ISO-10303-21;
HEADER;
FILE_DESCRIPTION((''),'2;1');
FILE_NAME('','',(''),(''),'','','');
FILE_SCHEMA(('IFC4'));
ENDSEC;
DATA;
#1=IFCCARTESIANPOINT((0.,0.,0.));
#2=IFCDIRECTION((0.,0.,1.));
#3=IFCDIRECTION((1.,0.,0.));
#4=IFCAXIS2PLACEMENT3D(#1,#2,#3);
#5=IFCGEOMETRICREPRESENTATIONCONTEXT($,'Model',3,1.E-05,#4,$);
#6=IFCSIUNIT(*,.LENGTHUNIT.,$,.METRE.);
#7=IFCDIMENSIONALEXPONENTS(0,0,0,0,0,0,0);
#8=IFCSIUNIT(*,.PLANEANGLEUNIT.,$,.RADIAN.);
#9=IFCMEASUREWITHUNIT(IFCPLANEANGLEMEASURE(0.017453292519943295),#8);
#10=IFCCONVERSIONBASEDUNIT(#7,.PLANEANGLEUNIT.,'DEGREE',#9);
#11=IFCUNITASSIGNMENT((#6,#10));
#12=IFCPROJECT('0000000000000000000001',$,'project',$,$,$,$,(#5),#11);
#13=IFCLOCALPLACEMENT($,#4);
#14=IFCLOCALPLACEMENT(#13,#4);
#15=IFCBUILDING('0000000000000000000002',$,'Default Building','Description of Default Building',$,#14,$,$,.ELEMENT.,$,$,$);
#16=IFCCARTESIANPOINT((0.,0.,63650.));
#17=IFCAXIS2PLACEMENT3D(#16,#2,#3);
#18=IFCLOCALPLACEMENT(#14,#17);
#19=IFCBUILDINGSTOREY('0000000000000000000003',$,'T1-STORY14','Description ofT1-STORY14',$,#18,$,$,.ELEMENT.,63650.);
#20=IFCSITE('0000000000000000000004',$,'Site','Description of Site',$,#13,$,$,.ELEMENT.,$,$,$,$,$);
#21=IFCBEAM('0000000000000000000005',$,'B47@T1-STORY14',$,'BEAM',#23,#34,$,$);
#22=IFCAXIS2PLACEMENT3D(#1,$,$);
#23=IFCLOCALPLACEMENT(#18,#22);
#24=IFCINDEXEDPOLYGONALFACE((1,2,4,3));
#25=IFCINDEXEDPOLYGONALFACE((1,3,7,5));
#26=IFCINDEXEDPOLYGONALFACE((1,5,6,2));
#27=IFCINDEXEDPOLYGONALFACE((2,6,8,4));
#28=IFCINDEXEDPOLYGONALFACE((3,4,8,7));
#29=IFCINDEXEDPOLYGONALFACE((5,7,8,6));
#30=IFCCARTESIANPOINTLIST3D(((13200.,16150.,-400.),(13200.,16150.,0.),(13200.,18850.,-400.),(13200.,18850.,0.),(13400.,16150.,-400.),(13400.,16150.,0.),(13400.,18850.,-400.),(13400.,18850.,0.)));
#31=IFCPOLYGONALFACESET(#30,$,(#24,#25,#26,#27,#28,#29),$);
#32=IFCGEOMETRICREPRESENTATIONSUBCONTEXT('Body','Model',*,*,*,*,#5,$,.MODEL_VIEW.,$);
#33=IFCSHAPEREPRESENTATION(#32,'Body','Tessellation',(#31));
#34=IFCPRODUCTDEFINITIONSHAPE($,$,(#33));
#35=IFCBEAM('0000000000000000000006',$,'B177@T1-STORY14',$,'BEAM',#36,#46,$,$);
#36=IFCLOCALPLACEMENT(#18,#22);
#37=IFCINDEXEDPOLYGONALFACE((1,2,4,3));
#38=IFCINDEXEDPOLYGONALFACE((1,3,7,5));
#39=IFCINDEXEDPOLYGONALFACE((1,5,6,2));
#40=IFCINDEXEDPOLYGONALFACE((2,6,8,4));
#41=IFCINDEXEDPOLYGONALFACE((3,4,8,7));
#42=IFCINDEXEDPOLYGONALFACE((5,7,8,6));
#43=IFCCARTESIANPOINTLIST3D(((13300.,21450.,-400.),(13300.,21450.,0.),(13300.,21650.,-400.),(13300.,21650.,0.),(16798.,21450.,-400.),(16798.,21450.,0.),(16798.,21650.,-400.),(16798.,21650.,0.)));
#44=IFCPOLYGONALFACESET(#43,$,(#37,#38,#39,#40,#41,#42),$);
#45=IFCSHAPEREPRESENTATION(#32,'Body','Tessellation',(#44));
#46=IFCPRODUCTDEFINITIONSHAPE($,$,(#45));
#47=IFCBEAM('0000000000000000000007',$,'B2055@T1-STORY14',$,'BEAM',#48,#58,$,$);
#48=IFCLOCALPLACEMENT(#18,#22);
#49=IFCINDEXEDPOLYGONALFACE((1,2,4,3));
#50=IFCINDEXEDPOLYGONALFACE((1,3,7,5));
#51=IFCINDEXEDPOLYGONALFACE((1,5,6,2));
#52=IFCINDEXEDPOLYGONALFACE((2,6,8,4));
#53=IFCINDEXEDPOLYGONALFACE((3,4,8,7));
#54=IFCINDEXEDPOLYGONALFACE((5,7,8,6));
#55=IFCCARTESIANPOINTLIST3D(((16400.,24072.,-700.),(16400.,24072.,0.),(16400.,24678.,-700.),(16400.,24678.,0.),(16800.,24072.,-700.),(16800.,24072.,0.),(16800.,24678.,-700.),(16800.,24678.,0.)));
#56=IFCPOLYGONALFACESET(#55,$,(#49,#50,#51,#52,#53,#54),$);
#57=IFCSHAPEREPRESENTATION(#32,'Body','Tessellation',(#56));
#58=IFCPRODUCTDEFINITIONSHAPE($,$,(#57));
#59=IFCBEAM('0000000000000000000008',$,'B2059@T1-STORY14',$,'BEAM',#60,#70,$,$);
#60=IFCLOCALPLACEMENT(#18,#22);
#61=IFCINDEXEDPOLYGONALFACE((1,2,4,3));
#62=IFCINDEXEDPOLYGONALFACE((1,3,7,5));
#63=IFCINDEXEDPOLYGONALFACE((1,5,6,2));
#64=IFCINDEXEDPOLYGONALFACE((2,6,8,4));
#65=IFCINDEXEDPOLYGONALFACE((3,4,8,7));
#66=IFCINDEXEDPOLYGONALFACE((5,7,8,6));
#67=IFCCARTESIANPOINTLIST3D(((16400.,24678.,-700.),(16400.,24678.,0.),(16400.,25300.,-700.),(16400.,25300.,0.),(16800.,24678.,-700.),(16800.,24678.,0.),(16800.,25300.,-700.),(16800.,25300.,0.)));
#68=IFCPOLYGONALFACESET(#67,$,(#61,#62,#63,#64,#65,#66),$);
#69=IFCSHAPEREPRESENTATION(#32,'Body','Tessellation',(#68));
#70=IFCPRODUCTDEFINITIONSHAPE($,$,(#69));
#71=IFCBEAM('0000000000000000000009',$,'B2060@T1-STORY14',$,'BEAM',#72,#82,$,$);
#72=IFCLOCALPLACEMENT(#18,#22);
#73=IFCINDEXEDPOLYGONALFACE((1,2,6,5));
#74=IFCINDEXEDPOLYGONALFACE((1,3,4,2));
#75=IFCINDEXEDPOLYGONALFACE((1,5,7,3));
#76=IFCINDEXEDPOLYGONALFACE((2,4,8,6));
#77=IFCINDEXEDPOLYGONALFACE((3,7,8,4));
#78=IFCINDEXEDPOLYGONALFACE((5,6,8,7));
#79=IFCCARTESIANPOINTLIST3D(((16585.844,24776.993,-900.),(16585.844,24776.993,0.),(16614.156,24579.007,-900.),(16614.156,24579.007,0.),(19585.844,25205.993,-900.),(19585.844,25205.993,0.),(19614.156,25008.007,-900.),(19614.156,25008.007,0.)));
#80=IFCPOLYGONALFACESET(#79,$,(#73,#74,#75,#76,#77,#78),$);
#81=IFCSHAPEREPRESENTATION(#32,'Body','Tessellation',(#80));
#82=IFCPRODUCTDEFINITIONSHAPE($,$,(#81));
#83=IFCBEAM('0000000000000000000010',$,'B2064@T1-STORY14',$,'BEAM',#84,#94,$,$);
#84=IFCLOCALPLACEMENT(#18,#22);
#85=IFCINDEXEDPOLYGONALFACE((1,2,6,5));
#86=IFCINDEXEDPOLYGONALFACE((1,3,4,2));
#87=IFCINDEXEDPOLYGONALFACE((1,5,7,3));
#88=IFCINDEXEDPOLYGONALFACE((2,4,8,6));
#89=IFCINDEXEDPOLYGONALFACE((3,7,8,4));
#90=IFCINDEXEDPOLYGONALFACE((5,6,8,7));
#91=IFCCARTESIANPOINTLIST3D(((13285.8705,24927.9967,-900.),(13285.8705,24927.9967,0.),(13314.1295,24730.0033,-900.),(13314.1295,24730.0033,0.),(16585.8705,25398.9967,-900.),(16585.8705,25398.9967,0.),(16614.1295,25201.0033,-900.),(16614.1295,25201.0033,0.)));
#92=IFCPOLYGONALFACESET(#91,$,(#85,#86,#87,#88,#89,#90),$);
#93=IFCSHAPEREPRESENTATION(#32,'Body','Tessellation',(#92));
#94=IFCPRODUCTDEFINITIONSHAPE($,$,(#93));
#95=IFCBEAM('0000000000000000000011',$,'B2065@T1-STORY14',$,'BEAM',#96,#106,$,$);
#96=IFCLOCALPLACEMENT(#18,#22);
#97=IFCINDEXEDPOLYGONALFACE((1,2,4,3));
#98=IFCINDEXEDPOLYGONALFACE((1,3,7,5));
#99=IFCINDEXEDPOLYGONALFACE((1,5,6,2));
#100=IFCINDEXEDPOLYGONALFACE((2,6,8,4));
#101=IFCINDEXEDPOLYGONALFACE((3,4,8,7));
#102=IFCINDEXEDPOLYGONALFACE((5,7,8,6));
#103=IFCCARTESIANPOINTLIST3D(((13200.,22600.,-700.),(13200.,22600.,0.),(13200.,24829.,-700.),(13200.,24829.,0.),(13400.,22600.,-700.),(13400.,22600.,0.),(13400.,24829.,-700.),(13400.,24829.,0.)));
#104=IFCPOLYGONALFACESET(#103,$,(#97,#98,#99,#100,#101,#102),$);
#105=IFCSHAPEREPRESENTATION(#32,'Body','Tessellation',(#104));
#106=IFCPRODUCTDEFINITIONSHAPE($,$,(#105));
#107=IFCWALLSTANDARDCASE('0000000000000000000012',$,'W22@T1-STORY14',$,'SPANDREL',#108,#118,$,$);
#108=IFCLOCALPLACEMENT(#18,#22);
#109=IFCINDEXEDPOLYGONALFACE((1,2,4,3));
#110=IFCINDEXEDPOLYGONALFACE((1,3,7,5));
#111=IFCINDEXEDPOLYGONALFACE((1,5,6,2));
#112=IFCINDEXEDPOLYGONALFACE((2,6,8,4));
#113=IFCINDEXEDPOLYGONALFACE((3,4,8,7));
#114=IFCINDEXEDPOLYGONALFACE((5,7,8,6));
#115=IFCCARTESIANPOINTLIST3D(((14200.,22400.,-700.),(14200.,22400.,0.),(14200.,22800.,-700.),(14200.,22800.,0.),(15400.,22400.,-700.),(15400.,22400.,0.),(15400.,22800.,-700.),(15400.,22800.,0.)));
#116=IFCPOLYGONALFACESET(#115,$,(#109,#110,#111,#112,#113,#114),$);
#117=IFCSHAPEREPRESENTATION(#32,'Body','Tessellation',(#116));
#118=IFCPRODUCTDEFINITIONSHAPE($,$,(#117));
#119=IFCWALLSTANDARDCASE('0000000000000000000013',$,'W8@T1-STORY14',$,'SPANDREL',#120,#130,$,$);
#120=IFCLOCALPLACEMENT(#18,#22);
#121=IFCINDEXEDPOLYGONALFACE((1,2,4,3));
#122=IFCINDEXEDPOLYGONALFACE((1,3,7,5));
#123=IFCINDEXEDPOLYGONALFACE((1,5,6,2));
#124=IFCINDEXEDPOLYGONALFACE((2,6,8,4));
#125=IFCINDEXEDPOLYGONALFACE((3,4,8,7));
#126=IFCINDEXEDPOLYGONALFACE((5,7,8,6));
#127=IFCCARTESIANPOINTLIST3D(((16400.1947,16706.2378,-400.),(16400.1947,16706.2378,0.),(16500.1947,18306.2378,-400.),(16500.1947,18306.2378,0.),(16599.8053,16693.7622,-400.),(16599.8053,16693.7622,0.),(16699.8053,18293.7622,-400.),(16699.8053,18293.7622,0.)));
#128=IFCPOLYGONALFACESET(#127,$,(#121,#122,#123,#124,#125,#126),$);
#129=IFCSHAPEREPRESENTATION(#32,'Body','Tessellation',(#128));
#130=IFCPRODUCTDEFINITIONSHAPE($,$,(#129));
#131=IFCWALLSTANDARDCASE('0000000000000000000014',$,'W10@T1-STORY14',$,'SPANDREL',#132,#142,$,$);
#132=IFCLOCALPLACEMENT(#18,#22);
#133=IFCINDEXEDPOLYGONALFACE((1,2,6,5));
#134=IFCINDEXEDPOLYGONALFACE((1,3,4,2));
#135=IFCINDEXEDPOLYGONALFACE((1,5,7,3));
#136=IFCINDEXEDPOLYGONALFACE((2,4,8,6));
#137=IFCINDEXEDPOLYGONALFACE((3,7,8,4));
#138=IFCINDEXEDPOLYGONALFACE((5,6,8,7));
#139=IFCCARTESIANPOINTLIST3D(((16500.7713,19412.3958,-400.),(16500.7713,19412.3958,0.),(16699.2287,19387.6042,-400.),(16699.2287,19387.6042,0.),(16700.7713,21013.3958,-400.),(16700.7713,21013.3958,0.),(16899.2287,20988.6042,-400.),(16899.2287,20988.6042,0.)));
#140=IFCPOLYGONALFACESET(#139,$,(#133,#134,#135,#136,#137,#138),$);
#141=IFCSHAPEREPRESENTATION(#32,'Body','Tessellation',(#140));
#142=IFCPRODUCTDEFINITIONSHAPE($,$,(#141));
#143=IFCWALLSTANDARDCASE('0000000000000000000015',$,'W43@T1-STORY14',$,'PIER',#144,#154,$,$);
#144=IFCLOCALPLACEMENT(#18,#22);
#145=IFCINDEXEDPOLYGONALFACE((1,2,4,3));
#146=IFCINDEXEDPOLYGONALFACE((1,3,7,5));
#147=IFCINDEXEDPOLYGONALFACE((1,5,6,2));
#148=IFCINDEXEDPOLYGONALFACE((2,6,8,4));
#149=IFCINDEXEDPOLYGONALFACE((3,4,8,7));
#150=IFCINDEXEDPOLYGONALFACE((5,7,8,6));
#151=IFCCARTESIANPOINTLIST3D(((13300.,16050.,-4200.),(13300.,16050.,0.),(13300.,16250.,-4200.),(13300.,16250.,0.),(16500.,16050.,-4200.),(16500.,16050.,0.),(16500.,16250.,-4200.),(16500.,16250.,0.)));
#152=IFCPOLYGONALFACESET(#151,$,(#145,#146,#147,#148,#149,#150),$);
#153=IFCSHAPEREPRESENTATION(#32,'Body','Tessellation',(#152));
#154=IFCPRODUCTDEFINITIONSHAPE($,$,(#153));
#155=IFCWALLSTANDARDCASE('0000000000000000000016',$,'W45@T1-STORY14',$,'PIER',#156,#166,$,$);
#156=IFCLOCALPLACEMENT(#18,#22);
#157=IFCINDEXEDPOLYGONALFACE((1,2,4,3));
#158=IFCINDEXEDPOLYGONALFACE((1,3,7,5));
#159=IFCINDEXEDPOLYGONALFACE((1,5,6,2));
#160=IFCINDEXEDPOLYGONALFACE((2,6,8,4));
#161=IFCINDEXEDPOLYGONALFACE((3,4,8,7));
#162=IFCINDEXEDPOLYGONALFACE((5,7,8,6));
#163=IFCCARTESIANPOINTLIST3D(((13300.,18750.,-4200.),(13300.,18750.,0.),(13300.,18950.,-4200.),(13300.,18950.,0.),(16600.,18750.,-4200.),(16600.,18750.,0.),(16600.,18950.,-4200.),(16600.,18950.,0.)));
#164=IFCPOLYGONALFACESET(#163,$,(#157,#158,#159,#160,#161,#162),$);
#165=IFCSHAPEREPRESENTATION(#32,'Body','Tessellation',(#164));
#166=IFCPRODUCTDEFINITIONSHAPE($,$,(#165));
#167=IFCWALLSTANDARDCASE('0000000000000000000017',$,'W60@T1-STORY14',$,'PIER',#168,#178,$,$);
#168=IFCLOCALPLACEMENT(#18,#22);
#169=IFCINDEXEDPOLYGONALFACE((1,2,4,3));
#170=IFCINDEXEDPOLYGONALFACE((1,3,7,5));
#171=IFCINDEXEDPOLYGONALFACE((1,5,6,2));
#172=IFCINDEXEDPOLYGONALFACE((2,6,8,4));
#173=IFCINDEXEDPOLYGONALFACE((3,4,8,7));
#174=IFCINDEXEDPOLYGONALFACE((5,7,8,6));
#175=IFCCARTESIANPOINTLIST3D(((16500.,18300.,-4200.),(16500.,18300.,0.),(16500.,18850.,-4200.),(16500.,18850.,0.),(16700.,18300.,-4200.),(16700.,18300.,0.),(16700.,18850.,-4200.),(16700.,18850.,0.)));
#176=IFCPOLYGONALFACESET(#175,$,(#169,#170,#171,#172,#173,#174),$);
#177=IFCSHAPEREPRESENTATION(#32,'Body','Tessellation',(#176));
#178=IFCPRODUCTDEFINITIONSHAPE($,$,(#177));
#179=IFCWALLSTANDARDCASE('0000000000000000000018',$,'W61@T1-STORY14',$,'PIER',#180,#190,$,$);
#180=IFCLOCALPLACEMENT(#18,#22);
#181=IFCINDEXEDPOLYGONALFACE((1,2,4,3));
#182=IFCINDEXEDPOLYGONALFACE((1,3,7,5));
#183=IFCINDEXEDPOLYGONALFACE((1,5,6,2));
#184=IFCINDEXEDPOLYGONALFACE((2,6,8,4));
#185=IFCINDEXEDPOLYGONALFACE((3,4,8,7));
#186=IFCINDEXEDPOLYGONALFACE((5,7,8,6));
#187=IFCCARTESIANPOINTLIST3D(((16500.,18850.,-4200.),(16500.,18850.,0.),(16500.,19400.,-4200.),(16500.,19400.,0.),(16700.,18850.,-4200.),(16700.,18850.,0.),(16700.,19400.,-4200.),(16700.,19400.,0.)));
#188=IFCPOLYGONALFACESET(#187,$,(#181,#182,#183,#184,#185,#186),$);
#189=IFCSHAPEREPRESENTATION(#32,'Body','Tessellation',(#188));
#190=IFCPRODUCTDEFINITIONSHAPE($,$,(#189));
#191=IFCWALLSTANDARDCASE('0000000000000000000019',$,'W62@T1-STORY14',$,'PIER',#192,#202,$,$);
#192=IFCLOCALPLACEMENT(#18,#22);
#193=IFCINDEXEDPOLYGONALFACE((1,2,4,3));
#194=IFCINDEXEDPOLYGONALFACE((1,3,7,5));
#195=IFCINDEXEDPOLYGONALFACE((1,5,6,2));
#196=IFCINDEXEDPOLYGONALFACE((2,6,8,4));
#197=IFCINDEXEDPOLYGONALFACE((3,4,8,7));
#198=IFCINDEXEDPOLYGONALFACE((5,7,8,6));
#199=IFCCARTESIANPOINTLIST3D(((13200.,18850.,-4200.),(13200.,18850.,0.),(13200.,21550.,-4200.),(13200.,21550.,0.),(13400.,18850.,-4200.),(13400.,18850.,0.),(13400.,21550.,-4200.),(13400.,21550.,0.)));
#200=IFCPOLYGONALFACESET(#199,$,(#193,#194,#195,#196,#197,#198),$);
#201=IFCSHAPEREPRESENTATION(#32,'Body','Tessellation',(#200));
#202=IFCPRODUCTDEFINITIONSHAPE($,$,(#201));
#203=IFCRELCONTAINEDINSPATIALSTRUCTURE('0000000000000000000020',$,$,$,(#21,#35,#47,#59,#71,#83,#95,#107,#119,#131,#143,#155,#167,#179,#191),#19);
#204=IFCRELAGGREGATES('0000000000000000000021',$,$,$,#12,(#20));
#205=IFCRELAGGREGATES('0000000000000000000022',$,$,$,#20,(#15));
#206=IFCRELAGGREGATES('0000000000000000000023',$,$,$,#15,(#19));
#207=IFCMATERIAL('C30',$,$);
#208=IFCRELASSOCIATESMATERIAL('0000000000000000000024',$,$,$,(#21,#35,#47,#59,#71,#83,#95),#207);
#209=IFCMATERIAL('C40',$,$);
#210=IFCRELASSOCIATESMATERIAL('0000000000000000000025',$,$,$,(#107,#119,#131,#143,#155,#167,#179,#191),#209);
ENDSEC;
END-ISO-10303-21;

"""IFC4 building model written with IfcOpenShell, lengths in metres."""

from ifc_helpers import new_model, entity, si_unit, converted_unit, frame, origin_with_axes, place, context, subcontext, project, spatial, indexed_curve, rectangle, outline, extrude, material, element, save


model = new_model("IFC4")

# Units and contexts
model_context = context("Model", 3, precision=1e-05, world=origin_with_axes())
body_context = subcontext(model_context, "Body", "Model", "MODEL_VIEW")
ifc_project = project(units=[si_unit("LENGTHUNIT", "METRE"), converted_unit("PLANEANGLEUNIT", "DEGREE", entity("IfcPlaneAngleMeasure", 0.017453292519943295), si_unit("PLANEANGLEUNIT", "RADIAN"), dimensions=[0, 0, 0, 0, 0, 0, 0])], contexts=[model_context])

# Site, building, storey
site_placement = place(None, origin_with_axes())
site = spatial("IfcSite", under=ifc_project, at=site_placement, Name="Site", Description="Description of Site", CompositionType="ELEMENT")
building_placement = place(site_placement, origin_with_axes())
building = spatial("IfcBuilding", under=site, at=building_placement, Name="Default Building", Description="Description of Default Building", CompositionType="ELEMENT")
storey_placement = place(building_placement, frame((0.0, 0.0, 63650.0), z_axis=(0.0, 0.0, 1.0), x_axis=(1.0, 0.0, 0.0)))
storey = spatial("IfcBuildingStorey", under=building, at=storey_placement, Name="T1-STORY14", Description="Description ofT1-STORY14", CompositionType="ELEMENT", Elevation=63650.0)

# Beams
ifc_material_1 = material(Name="C30")
beam_1_placement = place(storey_placement, frame((13300.0, 16150.0, -200.0), z_axis=(0.0, 1.0, 0.0), x_axis=(-1.0, 0.0, 0.0)))
element("IfcBeam", 1, at=beam_1_placement, inside=storey, material=ifc_material_1, Name="B47@T1-STORY14", ObjectType="BEAM", context=body_context, shape_type="SweptSolid", body=[
    extrude(rectangle(XDim=200.0, YDim=400.0), origin_with_axes(), (0.0, 0.0, 1.0), 2700.0),
])
beam_2_placement = place(storey_placement, frame((13300.0, 21550.0, -200.0), z_axis=(1.0, 0.0, 0.0), x_axis=(0.0, 1.0, 0.0)))
element("IfcBeam", 2, at=beam_2_placement, inside=storey, material=ifc_material_1, Name="B177@T1-STORY14", ObjectType="BEAM", context=body_context, shape_type="SweptSolid", body=[
    extrude(rectangle(XDim=200.0, YDim=400.0), origin_with_axes(), (0.0, 0.0, 1.0), 3498.0),
])
beam_3_placement = place(storey_placement, frame((16600.0, 24072.0, -350.0), z_axis=(0.0, 1.0, 0.0), x_axis=(-1.0, 0.0, 0.0)))
element("IfcBeam", 3, at=beam_3_placement, inside=storey, material=ifc_material_1, Name="B2055@T1-STORY14", ObjectType="BEAM", context=body_context, shape_type="SweptSolid", body=[
    extrude(rectangle(XDim=400.0, YDim=700.0), origin_with_axes(), (0.0, 0.0, 1.0), 606.0),
])
beam_4_placement = place(storey_placement, frame((16600.0, 24678.0, -350.0), z_axis=(0.0, 1.0, 0.0), x_axis=(-1.0, 0.0, 0.0)))
element("IfcBeam", 4, at=beam_4_placement, inside=storey, material=ifc_material_1, Name="B2059@T1-STORY14", ObjectType="BEAM", context=body_context, shape_type="SweptSolid", body=[
    extrude(rectangle(XDim=400.0, YDim=700.0), origin_with_axes(), (0.0, 0.0, 1.0), 622.0),
])
beam_5_placement = place(storey_placement, frame((16600.0, 24678.0, -450.0), z_axis=(0.98993, 0.14156, 0.0), x_axis=(-0.14156, 0.98993, 0.0)))
element("IfcBeam", 5, at=beam_5_placement, inside=storey, material=ifc_material_1, Name="B2060@T1-STORY14", ObjectType="BEAM", context=body_context, shape_type="SweptSolid", body=[
    extrude(rectangle(XDim=200.0, YDim=900.0), origin_with_axes(), (0.0, 0.0, 1.0), 3030.5183),
])
beam_6_placement = place(storey_placement, frame((13300.0, 24829.0, -450.0), z_axis=(0.989967, 0.141295, 0.0), x_axis=(-0.141295, 0.989967, 0.0)))
element("IfcBeam", 6, at=beam_6_placement, inside=storey, material=ifc_material_1, Name="B2064@T1-STORY14", ObjectType="BEAM", context=body_context, shape_type="SweptSolid", body=[
    extrude(rectangle(XDim=200.0, YDim=900.0), origin_with_axes(), (0.0, 0.0, 1.0), 3333.4428),
])
beam_7_placement = place(storey_placement, frame((13300.0, 22600.0, -350.0), z_axis=(0.0, 1.0, 0.0), x_axis=(-1.0, 0.0, 0.0)))
element("IfcBeam", 7, at=beam_7_placement, inside=storey, material=ifc_material_1, Name="B2065@T1-STORY14", ObjectType="BEAM", context=body_context, shape_type="SweptSolid", body=[
    extrude(rectangle(XDim=200.0, YDim=700.0), origin_with_axes(), (0.0, 0.0, 1.0), 2229.0),
])

# Walls
ifc_material_2 = material(Name="C40")
wall_1_placement = place(storey_placement, frame((14200.0, 22600.0, -700.0), z_axis=(0.0, 0.0, 1.0), x_axis=(1.0, 0.0, 0.0)))
element("IfcWallStandardCase", 8, at=wall_1_placement, inside=storey, material=ifc_material_2, Name="W22@T1-STORY14", ObjectType="SPANDREL", context=body_context, shape_type="SweptSolid", body=[
    extrude(outline(indexed_curve([(0.0, -200.0), (0.0, 200.0), (1200.0, 200.0), (1200.0, -200.0), (0.0, -200.0)], self_intersect=False)), origin_with_axes(), (0.0, 0.0, 1.0), 700.0),
])
wall_2_placement = place(storey_placement, frame((16500.0, 16700.0, -400.0), z_axis=(0.0, 0.0, 1.0), x_axis=(0.062378, 0.998053, 0.0)))
element("IfcWallStandardCase", 9, at=wall_2_placement, inside=storey, material=ifc_material_2, Name="W8@T1-STORY14", ObjectType="SPANDREL", context=body_context, shape_type="SweptSolid", body=[
    extrude(outline(indexed_curve([(0.0, -100.0), (0.0, 100.0), (1603.122, 100.0), (1603.122, -100.0), (0.0, -100.0)], self_intersect=False)), origin_with_axes(), (0.0, 0.0, 1.0), 400.0),
])
wall_3_placement = place(storey_placement, frame((16600.0, 19400.0, -400.0), z_axis=(0.0, 0.0, 1.0), x_axis=(0.123958, 0.992287, 0.0)))
element("IfcWallStandardCase", 10, at=wall_3_placement, inside=storey, material=ifc_material_2, Name="W10@T1-STORY14", ObjectType="SPANDREL", context=body_context, shape_type="SweptSolid", body=[
    extrude(outline(indexed_curve([(0.0, -100.0), (0.0, 100.0), (1613.4438, 100.0), (1613.4438, -100.0), (0.0, -100.0)], self_intersect=False)), origin_with_axes(), (0.0, 0.0, 1.0), 400.0),
])
wall_4_placement = place(storey_placement, frame((13300.0, 16150.0, -4200.0), z_axis=(0.0, 0.0, 1.0), x_axis=(1.0, 0.0, 0.0)))
element("IfcWallStandardCase", 11, at=wall_4_placement, inside=storey, material=ifc_material_2, Name="W43@T1-STORY14", ObjectType="PIER", context=body_context, shape_type="SweptSolid", body=[
    extrude(outline(indexed_curve([(0.0, -100.0), (0.0, 100.0), (3200.0, 100.0), (3200.0, -100.0), (0.0, -100.0)], self_intersect=False)), origin_with_axes(), (0.0, 0.0, 1.0), 4200.0),
])
wall_5_placement = place(storey_placement, frame((13300.0, 18850.0, -4200.0), z_axis=(0.0, 0.0, 1.0), x_axis=(1.0, 0.0, 0.0)))
element("IfcWallStandardCase", 12, at=wall_5_placement, inside=storey, material=ifc_material_2, Name="W45@T1-STORY14", ObjectType="PIER", context=body_context, shape_type="SweptSolid", body=[
    extrude(outline(indexed_curve([(0.0, -100.0), (0.0, 100.0), (3300.0, 100.0), (3300.0, -100.0), (0.0, -100.0)], self_intersect=False)), origin_with_axes(), (0.0, 0.0, 1.0), 4200.0),
])
for number, where, z_axis, x_axis, name in (
    (13, (16600.0, 18300.0, -4200.0), (0.0, 0.0, 1.0), (0.0, 1.0, 0.0), "W60@T1-STORY14"),
    (14, (16600.0, 18850.0, -4200.0), (0.0, 0.0, 1.0), (0.0, 1.0, 0.0), "W61@T1-STORY14"),
):
    element("IfcWallStandardCase", number, at=place(storey_placement, frame(where, z_axis=z_axis, x_axis=x_axis)), inside=storey, material=ifc_material_2, Name=name, ObjectType="PIER", context=body_context, shape_type="SweptSolid", body=[
        extrude(outline(indexed_curve([(0.0, -100.0), (0.0, 100.0), (550.0, 100.0), (550.0, -100.0), (0.0, -100.0)], self_intersect=False)), origin_with_axes(), (0.0, 0.0, 1.0), 4200.0),
    ])
wall_6_placement = place(storey_placement, frame((13300.0, 18850.0, -4200.0), z_axis=(0.0, 0.0, 1.0), x_axis=(0.0, 1.0, 0.0)))
element("IfcWallStandardCase", 15, at=wall_6_placement, inside=storey, material=ifc_material_2, Name="W62@T1-STORY14", ObjectType="PIER", context=body_context, shape_type="SweptSolid", body=[
    extrude(outline(indexed_curve([(0.0, -100.0), (0.0, 100.0), (2700.0, 100.0), (2700.0, -100.0), (0.0, -100.0)], self_intersect=False)), origin_with_axes(), (0.0, 0.0, 1.0), 4200.0),
])

save(model, "model.ifc")
